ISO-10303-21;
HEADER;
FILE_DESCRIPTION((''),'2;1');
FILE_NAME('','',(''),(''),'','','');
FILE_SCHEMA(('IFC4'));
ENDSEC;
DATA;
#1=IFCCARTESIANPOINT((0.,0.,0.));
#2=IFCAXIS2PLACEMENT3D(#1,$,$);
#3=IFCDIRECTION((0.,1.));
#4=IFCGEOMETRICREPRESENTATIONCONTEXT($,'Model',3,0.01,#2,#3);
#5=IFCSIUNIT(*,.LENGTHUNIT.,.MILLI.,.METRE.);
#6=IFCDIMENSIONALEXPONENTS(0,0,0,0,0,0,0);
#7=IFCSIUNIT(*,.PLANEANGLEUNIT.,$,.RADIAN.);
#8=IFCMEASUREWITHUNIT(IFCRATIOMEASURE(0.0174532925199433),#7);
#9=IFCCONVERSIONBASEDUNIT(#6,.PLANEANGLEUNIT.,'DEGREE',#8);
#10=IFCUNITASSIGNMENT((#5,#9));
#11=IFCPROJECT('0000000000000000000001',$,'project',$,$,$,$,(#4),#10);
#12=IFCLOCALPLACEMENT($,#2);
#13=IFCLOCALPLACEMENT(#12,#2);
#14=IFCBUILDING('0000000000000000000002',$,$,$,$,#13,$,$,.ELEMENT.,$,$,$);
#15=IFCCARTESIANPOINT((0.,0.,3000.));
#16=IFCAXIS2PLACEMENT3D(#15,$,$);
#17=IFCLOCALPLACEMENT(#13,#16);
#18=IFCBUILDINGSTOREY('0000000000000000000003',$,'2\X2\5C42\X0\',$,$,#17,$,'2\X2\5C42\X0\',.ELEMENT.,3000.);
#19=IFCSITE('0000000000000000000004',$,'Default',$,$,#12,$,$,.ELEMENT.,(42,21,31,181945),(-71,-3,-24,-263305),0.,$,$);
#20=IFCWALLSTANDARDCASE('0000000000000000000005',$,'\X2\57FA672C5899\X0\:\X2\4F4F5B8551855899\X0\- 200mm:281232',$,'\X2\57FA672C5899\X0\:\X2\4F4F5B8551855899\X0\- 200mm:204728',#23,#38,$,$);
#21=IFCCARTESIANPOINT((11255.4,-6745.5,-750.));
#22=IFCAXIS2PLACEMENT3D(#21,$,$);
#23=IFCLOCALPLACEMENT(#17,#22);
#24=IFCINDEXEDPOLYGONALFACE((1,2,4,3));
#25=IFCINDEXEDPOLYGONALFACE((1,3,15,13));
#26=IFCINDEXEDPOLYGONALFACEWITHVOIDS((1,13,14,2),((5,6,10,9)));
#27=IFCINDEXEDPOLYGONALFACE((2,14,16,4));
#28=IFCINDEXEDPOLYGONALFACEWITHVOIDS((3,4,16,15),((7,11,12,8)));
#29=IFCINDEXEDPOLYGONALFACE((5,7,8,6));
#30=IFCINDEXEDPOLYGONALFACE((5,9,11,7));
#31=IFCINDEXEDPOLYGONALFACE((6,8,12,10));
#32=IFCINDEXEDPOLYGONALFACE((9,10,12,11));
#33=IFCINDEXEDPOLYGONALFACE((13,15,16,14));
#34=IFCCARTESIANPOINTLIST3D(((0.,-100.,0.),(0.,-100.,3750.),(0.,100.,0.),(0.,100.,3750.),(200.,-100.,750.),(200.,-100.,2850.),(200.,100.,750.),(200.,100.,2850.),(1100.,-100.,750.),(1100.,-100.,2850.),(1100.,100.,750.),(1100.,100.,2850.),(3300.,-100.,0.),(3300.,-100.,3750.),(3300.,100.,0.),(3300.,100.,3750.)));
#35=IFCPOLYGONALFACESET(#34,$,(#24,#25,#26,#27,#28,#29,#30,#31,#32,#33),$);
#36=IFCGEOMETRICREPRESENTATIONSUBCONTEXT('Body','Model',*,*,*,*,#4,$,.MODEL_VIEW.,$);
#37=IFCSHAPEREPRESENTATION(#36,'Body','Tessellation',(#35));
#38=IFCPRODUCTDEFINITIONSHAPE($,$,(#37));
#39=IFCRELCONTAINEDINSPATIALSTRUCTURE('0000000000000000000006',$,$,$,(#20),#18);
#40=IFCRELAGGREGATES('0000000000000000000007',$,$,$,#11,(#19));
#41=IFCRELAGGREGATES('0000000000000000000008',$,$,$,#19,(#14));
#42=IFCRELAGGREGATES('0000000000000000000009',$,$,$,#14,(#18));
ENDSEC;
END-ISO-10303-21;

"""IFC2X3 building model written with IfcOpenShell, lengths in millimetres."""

from ifc_helpers import new_model, entity, si_unit, converted_unit, direction, frame, frame_2d, origin, place, context, subcontext, project, spatial, polyline, rectangle, extrude, clip, bounded_halfspace, element, save


model = new_model("IFC2X3")

# Units and contexts
model_context = context("Model", 3, precision=0.01, world=origin(), true_north=direction((0.0, 1.0)))
body_context = subcontext(model_context, "Body", "Model", "MODEL_VIEW")
ifc_project = project(units=[si_unit("LENGTHUNIT", "METRE", prefix="MILLI"), converted_unit("PLANEANGLEUNIT", "DEGREE", entity("IfcRatioMeasure", 0.0174532925199433), si_unit("PLANEANGLEUNIT", "RADIAN"), dimensions=[0, 0, 0, 0, 0, 0, 0])], contexts=[model_context])

# Site, building, storey
site_placement = place(None, origin())
site = spatial("IfcSite", under=ifc_project, at=site_placement, Name="Default", CompositionType="ELEMENT", RefLatitude=(42, 21, 31, 181945), RefLongitude=(-71, -3, -24, -263305), RefElevation=0.0)
building_placement = place(site_placement, origin())
building = spatial("IfcBuilding", under=site, at=building_placement, CompositionType="ELEMENT")
storey_placement = place(building_placement, frame((0.0, 0.0, 3000.0)))
storey = spatial("IfcBuildingStorey", under=building, at=storey_placement, Name="2层", LongName="2层", CompositionType="ELEMENT", Elevation=3000.0)

# Wall, openings
wall_1_placement = place(storey_placement, frame((11255.4, -6745.5, -750.0)))
wall_1 = element("IfcWallStandardCase", 1, at=wall_1_placement, inside=storey, Name="基本墙:住宅内墙- 200mm:281232", ObjectType="基本墙:住宅内墙- 200mm:204728", context=body_context, shape_type="Clipping", body=[
    clip(extrude(rectangle(XDim=3300.0, YDim=200.0, at=frame_2d((1650.0, 0.0), x_axis=(-1.0, 0.0))), origin(), (0.0, 0.0, 1.0), 3750.0), bounded_halfspace(frame((3300.0, -100.0, 3750.0), z_axis=(1.0, 0.0, 0.0), x_axis=(0.0, 0.0, -1.0)), False, frame((3300.0, -100.0, 3750.0), z_axis=(1.0, 0.0, 0.0), x_axis=(0.0, 0.0, -1.0)), polyline([(0.0, 0.0), (3750.0, 0.0), (3750.0, 200.0), (0.0, 200.0), (0.0, 0.0)]))),
])
opening_1_placement = place(wall_1_placement, origin())
element("IfcOpeningElement", 2, at=opening_1_placement, cuts=wall_1, ObjectType="Opening", context=body_context, shape_type="SweptSolid", body=[
    extrude(rectangle(XDim=2100.0, YDim=900.0, at=frame_2d((0.0, 0.0), x_axis=(1.0, 0.0))), frame((650.0, -1424.0, 4800.0), z_axis=(0.0, 1.0, 0.0), x_axis=(0.0, 0.0, 1.0)), (0.0, 0.0, 1.0), 3048.0),
])
opening_2_placement = place(wall_1_placement, origin())
element("IfcOpeningElement", 3, at=opening_2_placement, cuts=wall_1, ObjectType="Opening", context=body_context, shape_type="SweptSolid", body=[
    extrude(rectangle(XDim=2100.0, YDim=900.0, at=frame_2d((0.0, 0.0), x_axis=(1.0, 0.0))), frame((650.0, -1424.0, 1800.0), z_axis=(0.0, 1.0, 0.0), x_axis=(0.0, 0.0, 1.0)), (0.0, 0.0, 1.0), 3048.0),
])

save(model, "model.ifc")
